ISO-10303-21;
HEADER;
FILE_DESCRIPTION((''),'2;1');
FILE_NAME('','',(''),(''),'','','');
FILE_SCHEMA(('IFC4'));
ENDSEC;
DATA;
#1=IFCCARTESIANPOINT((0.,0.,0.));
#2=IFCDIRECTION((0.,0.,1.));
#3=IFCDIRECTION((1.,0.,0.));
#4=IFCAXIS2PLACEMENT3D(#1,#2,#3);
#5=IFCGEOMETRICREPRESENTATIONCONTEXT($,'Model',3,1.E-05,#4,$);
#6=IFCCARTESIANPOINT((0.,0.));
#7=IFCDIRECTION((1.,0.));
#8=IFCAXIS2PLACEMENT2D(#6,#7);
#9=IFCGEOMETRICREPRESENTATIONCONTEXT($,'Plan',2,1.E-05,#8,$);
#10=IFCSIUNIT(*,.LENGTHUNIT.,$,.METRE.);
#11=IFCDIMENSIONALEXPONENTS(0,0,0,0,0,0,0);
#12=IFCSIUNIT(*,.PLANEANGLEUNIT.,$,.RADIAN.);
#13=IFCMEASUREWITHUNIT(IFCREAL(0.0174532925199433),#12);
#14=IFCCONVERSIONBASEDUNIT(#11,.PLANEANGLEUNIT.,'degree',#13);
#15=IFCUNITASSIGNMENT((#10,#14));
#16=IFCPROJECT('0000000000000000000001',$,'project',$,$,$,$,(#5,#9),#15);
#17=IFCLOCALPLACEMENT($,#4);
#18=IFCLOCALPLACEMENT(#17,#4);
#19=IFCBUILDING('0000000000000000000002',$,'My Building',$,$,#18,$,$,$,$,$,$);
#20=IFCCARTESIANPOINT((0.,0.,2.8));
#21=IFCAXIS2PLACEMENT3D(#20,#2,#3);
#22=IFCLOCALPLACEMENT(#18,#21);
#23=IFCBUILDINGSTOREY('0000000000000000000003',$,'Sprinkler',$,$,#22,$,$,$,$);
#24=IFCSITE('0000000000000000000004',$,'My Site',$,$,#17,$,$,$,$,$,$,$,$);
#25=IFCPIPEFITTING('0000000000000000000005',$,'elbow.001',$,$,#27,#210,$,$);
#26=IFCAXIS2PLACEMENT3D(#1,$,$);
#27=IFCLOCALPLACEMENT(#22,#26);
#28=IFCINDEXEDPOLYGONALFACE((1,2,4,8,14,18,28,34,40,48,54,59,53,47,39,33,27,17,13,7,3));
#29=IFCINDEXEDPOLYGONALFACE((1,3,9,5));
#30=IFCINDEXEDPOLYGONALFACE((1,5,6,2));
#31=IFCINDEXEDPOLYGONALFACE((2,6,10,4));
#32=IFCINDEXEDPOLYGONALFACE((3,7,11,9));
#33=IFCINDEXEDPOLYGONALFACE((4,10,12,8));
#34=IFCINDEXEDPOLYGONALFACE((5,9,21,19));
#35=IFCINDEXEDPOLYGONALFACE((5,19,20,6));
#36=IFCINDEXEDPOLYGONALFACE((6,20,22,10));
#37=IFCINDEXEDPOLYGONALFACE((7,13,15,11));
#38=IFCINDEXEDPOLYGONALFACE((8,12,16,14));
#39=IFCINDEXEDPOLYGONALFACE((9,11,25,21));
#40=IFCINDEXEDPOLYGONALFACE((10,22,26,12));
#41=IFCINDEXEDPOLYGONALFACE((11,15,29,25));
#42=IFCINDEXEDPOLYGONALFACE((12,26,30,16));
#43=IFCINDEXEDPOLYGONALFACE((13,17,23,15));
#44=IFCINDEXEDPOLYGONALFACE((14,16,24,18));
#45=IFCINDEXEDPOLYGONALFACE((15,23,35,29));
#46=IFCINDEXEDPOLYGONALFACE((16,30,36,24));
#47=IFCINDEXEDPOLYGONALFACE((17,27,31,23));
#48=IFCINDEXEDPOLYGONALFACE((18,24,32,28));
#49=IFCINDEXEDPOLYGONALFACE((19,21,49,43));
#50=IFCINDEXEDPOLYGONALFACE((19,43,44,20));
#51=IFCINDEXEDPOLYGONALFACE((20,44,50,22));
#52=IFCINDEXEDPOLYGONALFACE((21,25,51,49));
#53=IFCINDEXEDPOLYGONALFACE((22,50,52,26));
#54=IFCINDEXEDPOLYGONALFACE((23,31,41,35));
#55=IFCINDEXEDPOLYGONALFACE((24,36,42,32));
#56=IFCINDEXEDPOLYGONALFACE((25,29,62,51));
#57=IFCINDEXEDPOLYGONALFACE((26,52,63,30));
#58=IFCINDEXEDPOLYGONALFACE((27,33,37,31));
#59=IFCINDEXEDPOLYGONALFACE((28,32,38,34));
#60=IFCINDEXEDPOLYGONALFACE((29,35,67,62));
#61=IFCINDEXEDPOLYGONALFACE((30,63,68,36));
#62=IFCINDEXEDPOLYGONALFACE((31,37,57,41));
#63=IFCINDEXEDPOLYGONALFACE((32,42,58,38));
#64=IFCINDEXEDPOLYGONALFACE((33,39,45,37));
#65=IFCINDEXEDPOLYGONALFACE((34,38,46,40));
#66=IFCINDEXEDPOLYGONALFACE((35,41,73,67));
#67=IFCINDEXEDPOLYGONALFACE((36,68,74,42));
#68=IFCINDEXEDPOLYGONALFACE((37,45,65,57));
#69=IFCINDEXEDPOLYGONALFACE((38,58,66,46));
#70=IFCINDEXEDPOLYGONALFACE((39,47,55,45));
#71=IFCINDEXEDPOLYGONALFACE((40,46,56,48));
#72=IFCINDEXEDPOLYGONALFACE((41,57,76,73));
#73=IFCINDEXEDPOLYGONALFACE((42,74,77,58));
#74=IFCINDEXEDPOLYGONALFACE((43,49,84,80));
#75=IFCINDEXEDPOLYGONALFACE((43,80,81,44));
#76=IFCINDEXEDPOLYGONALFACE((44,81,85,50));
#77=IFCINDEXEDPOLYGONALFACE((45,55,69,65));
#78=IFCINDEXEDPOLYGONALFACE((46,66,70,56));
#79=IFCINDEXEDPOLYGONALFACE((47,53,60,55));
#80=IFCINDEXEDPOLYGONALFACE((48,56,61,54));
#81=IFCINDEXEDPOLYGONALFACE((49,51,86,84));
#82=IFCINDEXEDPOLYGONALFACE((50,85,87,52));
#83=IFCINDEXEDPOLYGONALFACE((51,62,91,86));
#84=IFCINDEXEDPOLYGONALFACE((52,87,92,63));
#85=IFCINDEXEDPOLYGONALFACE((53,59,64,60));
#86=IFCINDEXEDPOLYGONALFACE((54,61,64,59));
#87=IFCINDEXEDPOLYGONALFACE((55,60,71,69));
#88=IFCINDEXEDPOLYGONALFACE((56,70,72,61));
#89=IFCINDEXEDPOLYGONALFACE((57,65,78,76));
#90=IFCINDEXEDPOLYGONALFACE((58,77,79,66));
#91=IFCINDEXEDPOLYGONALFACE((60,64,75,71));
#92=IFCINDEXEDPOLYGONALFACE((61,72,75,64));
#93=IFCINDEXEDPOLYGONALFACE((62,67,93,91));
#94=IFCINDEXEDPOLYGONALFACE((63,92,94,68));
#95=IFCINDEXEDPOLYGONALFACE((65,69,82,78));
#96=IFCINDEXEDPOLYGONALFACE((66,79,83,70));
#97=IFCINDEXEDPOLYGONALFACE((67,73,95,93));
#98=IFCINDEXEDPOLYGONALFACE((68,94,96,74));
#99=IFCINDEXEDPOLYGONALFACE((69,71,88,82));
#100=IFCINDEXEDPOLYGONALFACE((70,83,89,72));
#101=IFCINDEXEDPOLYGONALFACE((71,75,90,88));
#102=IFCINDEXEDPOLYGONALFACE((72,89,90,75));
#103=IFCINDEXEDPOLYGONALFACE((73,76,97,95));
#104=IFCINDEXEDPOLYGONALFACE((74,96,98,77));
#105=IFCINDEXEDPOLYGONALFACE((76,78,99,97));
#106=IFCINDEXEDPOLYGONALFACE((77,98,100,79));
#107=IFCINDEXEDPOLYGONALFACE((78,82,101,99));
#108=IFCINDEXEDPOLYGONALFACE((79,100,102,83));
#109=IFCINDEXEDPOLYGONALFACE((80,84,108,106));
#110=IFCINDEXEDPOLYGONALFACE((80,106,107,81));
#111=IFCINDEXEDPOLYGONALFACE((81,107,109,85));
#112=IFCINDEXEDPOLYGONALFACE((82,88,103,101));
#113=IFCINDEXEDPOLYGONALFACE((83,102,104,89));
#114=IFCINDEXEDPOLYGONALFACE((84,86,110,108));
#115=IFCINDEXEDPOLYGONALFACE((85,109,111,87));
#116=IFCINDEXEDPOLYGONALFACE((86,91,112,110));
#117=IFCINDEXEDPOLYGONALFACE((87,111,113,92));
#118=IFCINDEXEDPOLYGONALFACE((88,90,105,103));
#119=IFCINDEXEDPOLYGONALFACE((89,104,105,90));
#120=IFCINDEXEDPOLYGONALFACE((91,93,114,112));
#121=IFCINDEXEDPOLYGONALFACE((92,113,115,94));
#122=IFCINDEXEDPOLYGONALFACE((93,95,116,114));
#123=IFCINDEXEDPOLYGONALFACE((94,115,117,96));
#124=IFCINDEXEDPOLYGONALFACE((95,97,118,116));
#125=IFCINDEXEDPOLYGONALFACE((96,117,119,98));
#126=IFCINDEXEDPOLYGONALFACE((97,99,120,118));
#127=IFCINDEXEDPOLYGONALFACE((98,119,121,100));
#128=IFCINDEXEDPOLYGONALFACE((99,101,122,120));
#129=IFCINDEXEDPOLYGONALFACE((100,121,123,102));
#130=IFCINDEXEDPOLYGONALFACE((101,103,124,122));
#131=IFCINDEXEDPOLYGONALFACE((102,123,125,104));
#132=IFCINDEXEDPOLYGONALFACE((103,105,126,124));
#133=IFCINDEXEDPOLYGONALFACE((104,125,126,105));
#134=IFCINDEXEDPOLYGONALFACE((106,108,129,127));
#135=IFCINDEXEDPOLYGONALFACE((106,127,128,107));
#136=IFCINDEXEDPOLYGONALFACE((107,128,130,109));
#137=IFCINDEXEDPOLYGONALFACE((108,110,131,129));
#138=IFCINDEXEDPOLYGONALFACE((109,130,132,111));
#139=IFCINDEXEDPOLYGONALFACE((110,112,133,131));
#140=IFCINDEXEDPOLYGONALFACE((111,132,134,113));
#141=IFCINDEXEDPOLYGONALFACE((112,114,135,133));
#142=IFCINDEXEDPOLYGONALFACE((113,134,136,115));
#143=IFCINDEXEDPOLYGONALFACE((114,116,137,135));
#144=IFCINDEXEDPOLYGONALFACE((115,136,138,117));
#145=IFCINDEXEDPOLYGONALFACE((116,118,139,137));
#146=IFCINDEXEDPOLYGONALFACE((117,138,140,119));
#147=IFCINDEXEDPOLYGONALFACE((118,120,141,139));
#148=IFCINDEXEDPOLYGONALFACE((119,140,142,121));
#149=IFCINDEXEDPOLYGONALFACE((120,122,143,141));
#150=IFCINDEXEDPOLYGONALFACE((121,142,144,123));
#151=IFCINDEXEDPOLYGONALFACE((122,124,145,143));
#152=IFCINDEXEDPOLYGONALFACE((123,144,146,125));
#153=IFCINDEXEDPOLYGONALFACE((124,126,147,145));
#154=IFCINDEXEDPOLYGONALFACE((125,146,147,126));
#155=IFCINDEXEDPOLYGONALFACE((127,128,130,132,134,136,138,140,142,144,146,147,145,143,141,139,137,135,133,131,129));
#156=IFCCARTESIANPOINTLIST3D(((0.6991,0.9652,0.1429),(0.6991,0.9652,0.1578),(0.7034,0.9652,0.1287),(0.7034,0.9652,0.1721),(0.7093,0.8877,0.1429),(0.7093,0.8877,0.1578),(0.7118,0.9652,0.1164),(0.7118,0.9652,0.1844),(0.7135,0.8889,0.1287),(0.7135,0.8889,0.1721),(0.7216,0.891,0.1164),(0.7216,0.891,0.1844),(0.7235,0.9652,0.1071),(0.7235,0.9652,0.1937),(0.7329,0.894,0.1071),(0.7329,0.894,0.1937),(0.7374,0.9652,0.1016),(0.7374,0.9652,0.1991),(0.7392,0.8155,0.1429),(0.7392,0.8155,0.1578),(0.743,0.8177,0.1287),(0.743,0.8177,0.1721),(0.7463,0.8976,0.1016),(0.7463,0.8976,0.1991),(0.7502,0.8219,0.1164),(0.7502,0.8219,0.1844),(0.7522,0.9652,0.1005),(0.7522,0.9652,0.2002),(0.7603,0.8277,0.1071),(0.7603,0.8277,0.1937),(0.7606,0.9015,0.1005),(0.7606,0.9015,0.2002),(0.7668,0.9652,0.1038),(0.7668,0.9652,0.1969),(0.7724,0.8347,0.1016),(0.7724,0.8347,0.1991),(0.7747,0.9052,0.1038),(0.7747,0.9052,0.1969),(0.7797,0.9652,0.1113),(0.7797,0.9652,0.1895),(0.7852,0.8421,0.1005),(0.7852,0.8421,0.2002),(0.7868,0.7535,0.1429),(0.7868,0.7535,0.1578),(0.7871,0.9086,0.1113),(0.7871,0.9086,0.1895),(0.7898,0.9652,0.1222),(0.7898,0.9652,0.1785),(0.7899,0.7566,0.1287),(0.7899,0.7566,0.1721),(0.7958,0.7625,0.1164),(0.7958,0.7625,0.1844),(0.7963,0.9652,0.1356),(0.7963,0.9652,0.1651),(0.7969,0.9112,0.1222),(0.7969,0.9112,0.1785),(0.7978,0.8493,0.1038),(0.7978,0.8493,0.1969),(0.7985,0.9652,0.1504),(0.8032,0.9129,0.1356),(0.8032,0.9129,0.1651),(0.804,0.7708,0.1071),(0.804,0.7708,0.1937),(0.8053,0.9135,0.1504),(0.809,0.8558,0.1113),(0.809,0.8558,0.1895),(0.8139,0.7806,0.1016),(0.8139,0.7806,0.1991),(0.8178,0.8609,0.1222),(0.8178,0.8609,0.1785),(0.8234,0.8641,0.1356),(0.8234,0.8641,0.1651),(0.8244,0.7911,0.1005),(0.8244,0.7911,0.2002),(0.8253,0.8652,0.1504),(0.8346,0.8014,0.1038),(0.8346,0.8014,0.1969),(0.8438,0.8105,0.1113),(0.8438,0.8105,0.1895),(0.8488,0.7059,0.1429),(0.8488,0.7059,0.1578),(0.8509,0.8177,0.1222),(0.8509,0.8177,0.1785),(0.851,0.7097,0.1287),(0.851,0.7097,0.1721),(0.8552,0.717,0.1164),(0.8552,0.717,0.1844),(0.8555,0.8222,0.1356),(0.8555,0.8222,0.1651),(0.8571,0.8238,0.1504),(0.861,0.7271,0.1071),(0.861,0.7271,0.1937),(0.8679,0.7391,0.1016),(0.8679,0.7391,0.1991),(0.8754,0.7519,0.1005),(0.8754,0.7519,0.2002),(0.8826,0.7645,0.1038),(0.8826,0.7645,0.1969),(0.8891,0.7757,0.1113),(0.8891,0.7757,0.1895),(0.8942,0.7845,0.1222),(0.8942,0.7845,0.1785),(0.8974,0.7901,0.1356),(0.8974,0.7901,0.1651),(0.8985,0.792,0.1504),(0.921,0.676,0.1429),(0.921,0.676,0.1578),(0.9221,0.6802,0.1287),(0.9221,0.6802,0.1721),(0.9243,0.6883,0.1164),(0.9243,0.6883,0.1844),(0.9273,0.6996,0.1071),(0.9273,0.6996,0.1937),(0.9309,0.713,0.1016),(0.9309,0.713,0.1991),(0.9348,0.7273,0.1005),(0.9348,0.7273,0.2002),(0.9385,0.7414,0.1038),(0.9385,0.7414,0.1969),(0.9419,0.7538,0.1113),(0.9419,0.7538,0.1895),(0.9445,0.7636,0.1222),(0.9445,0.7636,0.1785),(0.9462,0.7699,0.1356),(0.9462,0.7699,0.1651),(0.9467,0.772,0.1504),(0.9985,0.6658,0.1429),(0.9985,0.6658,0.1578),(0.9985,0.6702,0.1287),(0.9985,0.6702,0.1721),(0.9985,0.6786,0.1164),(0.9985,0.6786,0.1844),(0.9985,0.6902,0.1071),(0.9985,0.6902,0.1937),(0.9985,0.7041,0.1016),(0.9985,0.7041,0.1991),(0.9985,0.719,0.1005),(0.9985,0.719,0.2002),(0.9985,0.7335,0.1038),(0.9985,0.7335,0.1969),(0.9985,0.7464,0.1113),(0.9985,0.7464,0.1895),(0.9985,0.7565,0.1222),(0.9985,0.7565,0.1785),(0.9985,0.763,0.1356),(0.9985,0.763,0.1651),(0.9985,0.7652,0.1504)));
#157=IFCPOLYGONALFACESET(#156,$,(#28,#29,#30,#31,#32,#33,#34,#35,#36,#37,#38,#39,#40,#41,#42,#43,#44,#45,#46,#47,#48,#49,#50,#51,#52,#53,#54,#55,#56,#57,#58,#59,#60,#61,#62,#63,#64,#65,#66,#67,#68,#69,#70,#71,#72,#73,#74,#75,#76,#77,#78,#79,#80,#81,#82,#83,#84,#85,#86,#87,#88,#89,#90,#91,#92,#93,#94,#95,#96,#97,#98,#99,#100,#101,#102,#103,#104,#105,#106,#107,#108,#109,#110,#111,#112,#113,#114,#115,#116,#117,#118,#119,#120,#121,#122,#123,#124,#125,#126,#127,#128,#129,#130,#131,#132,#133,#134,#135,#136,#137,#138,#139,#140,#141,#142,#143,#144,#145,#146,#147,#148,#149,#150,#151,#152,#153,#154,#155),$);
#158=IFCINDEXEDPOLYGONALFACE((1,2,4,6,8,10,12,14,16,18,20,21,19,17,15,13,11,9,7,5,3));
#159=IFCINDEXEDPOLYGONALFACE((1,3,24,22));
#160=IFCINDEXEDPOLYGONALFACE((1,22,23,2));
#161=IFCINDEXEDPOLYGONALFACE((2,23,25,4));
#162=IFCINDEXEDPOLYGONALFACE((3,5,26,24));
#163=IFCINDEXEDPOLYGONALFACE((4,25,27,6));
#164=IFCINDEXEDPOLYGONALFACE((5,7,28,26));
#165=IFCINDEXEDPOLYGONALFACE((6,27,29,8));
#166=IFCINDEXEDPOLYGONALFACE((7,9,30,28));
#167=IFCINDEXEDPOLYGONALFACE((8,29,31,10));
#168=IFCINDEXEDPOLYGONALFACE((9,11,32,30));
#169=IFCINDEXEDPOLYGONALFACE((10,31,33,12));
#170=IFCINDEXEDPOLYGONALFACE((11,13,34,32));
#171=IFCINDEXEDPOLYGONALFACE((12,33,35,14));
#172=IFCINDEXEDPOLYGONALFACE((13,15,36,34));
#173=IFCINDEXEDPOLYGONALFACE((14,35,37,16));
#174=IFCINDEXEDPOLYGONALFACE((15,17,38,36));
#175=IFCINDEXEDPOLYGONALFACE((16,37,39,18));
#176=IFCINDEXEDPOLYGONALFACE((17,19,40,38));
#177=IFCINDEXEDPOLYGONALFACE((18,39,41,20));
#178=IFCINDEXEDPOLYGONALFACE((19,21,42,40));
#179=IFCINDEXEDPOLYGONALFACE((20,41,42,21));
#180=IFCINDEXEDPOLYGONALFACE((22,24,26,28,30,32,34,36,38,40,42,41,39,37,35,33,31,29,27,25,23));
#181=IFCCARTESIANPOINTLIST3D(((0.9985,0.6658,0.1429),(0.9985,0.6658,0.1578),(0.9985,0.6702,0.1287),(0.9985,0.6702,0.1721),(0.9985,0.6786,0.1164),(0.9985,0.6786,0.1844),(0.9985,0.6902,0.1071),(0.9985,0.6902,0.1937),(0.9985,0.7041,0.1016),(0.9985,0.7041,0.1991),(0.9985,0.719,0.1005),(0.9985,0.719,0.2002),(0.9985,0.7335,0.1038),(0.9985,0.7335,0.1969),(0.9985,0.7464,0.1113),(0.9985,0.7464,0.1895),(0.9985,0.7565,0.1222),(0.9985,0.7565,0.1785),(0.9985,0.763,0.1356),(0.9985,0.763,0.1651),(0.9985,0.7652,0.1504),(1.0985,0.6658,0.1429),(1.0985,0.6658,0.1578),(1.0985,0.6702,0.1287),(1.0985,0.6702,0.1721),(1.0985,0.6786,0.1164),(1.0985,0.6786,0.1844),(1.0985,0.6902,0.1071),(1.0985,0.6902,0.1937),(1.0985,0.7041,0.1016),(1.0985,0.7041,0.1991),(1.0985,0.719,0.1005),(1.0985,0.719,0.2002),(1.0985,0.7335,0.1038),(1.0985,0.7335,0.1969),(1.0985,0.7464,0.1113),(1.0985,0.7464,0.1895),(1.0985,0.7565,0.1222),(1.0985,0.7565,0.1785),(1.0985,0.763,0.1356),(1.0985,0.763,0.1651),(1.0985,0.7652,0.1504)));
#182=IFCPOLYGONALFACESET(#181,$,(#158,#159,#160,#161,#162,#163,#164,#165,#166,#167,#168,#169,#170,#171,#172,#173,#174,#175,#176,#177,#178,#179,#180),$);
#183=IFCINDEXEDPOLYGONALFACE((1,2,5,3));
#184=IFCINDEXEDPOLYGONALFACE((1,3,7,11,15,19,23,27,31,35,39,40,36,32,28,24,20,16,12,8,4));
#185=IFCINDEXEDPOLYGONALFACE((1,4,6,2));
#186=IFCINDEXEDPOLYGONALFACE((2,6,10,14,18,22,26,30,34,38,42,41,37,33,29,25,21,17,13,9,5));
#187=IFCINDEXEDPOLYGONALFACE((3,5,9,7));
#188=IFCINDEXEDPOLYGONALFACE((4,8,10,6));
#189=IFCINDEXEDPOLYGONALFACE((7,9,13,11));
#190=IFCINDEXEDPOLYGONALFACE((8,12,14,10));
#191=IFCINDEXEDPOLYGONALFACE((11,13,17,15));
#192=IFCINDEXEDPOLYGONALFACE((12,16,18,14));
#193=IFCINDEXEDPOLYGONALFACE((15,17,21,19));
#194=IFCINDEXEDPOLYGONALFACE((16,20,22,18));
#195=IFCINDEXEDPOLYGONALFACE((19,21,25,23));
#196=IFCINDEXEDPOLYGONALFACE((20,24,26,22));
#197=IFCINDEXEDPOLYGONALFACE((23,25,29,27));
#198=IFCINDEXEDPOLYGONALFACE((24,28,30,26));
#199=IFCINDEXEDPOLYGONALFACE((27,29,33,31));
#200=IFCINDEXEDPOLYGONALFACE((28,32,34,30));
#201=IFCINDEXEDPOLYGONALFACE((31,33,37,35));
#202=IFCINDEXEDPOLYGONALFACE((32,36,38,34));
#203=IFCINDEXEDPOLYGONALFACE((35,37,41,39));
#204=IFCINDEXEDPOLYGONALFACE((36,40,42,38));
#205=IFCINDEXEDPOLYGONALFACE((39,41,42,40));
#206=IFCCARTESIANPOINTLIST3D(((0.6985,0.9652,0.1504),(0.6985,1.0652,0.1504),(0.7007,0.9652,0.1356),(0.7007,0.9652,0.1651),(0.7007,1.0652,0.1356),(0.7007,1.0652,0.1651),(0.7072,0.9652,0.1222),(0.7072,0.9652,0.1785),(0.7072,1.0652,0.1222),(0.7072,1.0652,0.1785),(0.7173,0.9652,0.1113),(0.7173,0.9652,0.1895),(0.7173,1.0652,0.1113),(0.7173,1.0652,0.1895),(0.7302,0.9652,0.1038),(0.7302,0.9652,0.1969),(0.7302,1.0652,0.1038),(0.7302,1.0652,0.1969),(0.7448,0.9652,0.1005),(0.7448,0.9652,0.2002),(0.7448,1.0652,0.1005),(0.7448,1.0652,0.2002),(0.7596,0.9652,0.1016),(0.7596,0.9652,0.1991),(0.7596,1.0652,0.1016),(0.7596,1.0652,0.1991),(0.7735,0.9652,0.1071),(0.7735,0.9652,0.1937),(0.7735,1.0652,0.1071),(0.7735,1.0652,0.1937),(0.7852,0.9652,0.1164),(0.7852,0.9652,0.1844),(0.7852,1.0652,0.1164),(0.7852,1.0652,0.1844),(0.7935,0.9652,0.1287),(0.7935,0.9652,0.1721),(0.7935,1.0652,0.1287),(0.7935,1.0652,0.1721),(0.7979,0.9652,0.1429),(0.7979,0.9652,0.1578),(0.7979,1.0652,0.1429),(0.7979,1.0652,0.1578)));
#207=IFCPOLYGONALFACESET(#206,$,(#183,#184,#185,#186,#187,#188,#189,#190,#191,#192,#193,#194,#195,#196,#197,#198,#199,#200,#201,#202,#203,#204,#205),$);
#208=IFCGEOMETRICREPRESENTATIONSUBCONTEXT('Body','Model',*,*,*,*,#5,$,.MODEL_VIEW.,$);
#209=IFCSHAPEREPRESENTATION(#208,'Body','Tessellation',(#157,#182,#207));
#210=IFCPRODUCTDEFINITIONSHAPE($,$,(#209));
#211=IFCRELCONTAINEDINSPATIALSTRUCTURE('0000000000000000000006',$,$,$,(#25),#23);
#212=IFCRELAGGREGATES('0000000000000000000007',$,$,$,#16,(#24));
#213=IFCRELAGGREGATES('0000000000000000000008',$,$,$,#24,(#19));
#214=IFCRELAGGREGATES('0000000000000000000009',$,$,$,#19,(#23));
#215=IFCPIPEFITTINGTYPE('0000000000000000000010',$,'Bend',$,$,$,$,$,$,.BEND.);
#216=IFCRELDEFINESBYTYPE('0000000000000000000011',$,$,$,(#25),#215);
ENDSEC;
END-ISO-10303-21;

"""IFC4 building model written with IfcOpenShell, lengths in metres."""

from ifc_helpers import new_model, entity, si_unit, converted_unit, frame, origin_with_axes, origin_2d_with_axis, place, context, subcontext, project, spatial, circle, extrude, source, transform, mapped, type_object, type_shapes, element, save


model = new_model("IFC4")

# Units and contexts
model_context = context("Model", 3, precision=1e-05, world=origin_with_axes())
plan_context = context("Plan", 2, precision=1e-05, world=origin_2d_with_axis())
body_context = subcontext(model_context, "Body", "Model", "MODEL_VIEW")
ifc_project = project(units=[si_unit("LENGTHUNIT", "METRE"), converted_unit("PLANEANGLEUNIT", "degree", entity("IfcReal", 0.0174532925199433), si_unit("PLANEANGLEUNIT", "RADIAN"), dimensions=[0, 0, 0, 0, 0, 0, 0])], contexts=[model_context, plan_context])

# Site, building, storey
site_placement = place(None, origin_with_axes())
site = spatial("IfcSite", under=ifc_project, at=site_placement, Name="My Site")
building_placement = place(site_placement, origin_with_axes())
building = spatial("IfcBuilding", under=site, at=building_placement, Name="My Building")
storey_placement = place(building_placement, frame((0.0, 0.0, 2.8), z_axis=(0.0, 0.0, 1.0), x_axis=(1.0, 0.0, 0.0)))
storey = spatial("IfcBuildingStorey", under=building, at=storey_placement, Name="Sprinkler")

# Pipe fitting
pipe_fitting_type_1 = type_object("IfcPipeFittingType", Name="Bend", PredefinedType="BEND")
shared_shape = source(origin_with_axes(), body_context, "Body", "SolidModel", [
    entity("IfcSweptDiskSolid", entity("IfcIndexedPolyCurve", entity("IfcCartesianPointList3D", [[0.0, 0.0, 0.1], [0.0732, 0.0, 0.2768], [0.25, 0.0, 0.35]]), [entity("IfcArcIndex", [1, 2, 3])]), 0.05),
    extrude(circle(Radius=0.05), origin_with_axes(), (0.0, 0.0, 1.0), 0.1),
    extrude(circle(Radius=0.05), frame((0.25, 0.0, 0.35), z_axis=(1.0, 0.0, 0.000001), x_axis=(-0.000001, 0.0, 1.0)), (0.0, 0.0, 1.0), 0.1),
])
type_shapes(pipe_fitting_type_1, [shared_shape])
for number, where, z_axis, x_axis, name in (
    (1, (1.0985, 0.7152, 0.1504), (-1.0, 0.0, 0.0), (0.0, 1.0, 0.0), "elbow.001"),
):
    element("IfcPipeFitting", number, at=place(storey_placement, frame(where, z_axis=z_axis, x_axis=x_axis)), inside=storey, type_object=pipe_fitting_type_1, Name=name, context=body_context, shape_type="MappedRepresentation", body=[
        mapped(shared_shape, transform((0.0, 0.0, 0.0), x_axis=(1.0, 0.0, 0.0), y_axis=(0.0, 1.0, 0.0), z_axis=(0.0, 0.0, 1.0), scale=1.0)),
    ])

save(model, "model.ifc")
